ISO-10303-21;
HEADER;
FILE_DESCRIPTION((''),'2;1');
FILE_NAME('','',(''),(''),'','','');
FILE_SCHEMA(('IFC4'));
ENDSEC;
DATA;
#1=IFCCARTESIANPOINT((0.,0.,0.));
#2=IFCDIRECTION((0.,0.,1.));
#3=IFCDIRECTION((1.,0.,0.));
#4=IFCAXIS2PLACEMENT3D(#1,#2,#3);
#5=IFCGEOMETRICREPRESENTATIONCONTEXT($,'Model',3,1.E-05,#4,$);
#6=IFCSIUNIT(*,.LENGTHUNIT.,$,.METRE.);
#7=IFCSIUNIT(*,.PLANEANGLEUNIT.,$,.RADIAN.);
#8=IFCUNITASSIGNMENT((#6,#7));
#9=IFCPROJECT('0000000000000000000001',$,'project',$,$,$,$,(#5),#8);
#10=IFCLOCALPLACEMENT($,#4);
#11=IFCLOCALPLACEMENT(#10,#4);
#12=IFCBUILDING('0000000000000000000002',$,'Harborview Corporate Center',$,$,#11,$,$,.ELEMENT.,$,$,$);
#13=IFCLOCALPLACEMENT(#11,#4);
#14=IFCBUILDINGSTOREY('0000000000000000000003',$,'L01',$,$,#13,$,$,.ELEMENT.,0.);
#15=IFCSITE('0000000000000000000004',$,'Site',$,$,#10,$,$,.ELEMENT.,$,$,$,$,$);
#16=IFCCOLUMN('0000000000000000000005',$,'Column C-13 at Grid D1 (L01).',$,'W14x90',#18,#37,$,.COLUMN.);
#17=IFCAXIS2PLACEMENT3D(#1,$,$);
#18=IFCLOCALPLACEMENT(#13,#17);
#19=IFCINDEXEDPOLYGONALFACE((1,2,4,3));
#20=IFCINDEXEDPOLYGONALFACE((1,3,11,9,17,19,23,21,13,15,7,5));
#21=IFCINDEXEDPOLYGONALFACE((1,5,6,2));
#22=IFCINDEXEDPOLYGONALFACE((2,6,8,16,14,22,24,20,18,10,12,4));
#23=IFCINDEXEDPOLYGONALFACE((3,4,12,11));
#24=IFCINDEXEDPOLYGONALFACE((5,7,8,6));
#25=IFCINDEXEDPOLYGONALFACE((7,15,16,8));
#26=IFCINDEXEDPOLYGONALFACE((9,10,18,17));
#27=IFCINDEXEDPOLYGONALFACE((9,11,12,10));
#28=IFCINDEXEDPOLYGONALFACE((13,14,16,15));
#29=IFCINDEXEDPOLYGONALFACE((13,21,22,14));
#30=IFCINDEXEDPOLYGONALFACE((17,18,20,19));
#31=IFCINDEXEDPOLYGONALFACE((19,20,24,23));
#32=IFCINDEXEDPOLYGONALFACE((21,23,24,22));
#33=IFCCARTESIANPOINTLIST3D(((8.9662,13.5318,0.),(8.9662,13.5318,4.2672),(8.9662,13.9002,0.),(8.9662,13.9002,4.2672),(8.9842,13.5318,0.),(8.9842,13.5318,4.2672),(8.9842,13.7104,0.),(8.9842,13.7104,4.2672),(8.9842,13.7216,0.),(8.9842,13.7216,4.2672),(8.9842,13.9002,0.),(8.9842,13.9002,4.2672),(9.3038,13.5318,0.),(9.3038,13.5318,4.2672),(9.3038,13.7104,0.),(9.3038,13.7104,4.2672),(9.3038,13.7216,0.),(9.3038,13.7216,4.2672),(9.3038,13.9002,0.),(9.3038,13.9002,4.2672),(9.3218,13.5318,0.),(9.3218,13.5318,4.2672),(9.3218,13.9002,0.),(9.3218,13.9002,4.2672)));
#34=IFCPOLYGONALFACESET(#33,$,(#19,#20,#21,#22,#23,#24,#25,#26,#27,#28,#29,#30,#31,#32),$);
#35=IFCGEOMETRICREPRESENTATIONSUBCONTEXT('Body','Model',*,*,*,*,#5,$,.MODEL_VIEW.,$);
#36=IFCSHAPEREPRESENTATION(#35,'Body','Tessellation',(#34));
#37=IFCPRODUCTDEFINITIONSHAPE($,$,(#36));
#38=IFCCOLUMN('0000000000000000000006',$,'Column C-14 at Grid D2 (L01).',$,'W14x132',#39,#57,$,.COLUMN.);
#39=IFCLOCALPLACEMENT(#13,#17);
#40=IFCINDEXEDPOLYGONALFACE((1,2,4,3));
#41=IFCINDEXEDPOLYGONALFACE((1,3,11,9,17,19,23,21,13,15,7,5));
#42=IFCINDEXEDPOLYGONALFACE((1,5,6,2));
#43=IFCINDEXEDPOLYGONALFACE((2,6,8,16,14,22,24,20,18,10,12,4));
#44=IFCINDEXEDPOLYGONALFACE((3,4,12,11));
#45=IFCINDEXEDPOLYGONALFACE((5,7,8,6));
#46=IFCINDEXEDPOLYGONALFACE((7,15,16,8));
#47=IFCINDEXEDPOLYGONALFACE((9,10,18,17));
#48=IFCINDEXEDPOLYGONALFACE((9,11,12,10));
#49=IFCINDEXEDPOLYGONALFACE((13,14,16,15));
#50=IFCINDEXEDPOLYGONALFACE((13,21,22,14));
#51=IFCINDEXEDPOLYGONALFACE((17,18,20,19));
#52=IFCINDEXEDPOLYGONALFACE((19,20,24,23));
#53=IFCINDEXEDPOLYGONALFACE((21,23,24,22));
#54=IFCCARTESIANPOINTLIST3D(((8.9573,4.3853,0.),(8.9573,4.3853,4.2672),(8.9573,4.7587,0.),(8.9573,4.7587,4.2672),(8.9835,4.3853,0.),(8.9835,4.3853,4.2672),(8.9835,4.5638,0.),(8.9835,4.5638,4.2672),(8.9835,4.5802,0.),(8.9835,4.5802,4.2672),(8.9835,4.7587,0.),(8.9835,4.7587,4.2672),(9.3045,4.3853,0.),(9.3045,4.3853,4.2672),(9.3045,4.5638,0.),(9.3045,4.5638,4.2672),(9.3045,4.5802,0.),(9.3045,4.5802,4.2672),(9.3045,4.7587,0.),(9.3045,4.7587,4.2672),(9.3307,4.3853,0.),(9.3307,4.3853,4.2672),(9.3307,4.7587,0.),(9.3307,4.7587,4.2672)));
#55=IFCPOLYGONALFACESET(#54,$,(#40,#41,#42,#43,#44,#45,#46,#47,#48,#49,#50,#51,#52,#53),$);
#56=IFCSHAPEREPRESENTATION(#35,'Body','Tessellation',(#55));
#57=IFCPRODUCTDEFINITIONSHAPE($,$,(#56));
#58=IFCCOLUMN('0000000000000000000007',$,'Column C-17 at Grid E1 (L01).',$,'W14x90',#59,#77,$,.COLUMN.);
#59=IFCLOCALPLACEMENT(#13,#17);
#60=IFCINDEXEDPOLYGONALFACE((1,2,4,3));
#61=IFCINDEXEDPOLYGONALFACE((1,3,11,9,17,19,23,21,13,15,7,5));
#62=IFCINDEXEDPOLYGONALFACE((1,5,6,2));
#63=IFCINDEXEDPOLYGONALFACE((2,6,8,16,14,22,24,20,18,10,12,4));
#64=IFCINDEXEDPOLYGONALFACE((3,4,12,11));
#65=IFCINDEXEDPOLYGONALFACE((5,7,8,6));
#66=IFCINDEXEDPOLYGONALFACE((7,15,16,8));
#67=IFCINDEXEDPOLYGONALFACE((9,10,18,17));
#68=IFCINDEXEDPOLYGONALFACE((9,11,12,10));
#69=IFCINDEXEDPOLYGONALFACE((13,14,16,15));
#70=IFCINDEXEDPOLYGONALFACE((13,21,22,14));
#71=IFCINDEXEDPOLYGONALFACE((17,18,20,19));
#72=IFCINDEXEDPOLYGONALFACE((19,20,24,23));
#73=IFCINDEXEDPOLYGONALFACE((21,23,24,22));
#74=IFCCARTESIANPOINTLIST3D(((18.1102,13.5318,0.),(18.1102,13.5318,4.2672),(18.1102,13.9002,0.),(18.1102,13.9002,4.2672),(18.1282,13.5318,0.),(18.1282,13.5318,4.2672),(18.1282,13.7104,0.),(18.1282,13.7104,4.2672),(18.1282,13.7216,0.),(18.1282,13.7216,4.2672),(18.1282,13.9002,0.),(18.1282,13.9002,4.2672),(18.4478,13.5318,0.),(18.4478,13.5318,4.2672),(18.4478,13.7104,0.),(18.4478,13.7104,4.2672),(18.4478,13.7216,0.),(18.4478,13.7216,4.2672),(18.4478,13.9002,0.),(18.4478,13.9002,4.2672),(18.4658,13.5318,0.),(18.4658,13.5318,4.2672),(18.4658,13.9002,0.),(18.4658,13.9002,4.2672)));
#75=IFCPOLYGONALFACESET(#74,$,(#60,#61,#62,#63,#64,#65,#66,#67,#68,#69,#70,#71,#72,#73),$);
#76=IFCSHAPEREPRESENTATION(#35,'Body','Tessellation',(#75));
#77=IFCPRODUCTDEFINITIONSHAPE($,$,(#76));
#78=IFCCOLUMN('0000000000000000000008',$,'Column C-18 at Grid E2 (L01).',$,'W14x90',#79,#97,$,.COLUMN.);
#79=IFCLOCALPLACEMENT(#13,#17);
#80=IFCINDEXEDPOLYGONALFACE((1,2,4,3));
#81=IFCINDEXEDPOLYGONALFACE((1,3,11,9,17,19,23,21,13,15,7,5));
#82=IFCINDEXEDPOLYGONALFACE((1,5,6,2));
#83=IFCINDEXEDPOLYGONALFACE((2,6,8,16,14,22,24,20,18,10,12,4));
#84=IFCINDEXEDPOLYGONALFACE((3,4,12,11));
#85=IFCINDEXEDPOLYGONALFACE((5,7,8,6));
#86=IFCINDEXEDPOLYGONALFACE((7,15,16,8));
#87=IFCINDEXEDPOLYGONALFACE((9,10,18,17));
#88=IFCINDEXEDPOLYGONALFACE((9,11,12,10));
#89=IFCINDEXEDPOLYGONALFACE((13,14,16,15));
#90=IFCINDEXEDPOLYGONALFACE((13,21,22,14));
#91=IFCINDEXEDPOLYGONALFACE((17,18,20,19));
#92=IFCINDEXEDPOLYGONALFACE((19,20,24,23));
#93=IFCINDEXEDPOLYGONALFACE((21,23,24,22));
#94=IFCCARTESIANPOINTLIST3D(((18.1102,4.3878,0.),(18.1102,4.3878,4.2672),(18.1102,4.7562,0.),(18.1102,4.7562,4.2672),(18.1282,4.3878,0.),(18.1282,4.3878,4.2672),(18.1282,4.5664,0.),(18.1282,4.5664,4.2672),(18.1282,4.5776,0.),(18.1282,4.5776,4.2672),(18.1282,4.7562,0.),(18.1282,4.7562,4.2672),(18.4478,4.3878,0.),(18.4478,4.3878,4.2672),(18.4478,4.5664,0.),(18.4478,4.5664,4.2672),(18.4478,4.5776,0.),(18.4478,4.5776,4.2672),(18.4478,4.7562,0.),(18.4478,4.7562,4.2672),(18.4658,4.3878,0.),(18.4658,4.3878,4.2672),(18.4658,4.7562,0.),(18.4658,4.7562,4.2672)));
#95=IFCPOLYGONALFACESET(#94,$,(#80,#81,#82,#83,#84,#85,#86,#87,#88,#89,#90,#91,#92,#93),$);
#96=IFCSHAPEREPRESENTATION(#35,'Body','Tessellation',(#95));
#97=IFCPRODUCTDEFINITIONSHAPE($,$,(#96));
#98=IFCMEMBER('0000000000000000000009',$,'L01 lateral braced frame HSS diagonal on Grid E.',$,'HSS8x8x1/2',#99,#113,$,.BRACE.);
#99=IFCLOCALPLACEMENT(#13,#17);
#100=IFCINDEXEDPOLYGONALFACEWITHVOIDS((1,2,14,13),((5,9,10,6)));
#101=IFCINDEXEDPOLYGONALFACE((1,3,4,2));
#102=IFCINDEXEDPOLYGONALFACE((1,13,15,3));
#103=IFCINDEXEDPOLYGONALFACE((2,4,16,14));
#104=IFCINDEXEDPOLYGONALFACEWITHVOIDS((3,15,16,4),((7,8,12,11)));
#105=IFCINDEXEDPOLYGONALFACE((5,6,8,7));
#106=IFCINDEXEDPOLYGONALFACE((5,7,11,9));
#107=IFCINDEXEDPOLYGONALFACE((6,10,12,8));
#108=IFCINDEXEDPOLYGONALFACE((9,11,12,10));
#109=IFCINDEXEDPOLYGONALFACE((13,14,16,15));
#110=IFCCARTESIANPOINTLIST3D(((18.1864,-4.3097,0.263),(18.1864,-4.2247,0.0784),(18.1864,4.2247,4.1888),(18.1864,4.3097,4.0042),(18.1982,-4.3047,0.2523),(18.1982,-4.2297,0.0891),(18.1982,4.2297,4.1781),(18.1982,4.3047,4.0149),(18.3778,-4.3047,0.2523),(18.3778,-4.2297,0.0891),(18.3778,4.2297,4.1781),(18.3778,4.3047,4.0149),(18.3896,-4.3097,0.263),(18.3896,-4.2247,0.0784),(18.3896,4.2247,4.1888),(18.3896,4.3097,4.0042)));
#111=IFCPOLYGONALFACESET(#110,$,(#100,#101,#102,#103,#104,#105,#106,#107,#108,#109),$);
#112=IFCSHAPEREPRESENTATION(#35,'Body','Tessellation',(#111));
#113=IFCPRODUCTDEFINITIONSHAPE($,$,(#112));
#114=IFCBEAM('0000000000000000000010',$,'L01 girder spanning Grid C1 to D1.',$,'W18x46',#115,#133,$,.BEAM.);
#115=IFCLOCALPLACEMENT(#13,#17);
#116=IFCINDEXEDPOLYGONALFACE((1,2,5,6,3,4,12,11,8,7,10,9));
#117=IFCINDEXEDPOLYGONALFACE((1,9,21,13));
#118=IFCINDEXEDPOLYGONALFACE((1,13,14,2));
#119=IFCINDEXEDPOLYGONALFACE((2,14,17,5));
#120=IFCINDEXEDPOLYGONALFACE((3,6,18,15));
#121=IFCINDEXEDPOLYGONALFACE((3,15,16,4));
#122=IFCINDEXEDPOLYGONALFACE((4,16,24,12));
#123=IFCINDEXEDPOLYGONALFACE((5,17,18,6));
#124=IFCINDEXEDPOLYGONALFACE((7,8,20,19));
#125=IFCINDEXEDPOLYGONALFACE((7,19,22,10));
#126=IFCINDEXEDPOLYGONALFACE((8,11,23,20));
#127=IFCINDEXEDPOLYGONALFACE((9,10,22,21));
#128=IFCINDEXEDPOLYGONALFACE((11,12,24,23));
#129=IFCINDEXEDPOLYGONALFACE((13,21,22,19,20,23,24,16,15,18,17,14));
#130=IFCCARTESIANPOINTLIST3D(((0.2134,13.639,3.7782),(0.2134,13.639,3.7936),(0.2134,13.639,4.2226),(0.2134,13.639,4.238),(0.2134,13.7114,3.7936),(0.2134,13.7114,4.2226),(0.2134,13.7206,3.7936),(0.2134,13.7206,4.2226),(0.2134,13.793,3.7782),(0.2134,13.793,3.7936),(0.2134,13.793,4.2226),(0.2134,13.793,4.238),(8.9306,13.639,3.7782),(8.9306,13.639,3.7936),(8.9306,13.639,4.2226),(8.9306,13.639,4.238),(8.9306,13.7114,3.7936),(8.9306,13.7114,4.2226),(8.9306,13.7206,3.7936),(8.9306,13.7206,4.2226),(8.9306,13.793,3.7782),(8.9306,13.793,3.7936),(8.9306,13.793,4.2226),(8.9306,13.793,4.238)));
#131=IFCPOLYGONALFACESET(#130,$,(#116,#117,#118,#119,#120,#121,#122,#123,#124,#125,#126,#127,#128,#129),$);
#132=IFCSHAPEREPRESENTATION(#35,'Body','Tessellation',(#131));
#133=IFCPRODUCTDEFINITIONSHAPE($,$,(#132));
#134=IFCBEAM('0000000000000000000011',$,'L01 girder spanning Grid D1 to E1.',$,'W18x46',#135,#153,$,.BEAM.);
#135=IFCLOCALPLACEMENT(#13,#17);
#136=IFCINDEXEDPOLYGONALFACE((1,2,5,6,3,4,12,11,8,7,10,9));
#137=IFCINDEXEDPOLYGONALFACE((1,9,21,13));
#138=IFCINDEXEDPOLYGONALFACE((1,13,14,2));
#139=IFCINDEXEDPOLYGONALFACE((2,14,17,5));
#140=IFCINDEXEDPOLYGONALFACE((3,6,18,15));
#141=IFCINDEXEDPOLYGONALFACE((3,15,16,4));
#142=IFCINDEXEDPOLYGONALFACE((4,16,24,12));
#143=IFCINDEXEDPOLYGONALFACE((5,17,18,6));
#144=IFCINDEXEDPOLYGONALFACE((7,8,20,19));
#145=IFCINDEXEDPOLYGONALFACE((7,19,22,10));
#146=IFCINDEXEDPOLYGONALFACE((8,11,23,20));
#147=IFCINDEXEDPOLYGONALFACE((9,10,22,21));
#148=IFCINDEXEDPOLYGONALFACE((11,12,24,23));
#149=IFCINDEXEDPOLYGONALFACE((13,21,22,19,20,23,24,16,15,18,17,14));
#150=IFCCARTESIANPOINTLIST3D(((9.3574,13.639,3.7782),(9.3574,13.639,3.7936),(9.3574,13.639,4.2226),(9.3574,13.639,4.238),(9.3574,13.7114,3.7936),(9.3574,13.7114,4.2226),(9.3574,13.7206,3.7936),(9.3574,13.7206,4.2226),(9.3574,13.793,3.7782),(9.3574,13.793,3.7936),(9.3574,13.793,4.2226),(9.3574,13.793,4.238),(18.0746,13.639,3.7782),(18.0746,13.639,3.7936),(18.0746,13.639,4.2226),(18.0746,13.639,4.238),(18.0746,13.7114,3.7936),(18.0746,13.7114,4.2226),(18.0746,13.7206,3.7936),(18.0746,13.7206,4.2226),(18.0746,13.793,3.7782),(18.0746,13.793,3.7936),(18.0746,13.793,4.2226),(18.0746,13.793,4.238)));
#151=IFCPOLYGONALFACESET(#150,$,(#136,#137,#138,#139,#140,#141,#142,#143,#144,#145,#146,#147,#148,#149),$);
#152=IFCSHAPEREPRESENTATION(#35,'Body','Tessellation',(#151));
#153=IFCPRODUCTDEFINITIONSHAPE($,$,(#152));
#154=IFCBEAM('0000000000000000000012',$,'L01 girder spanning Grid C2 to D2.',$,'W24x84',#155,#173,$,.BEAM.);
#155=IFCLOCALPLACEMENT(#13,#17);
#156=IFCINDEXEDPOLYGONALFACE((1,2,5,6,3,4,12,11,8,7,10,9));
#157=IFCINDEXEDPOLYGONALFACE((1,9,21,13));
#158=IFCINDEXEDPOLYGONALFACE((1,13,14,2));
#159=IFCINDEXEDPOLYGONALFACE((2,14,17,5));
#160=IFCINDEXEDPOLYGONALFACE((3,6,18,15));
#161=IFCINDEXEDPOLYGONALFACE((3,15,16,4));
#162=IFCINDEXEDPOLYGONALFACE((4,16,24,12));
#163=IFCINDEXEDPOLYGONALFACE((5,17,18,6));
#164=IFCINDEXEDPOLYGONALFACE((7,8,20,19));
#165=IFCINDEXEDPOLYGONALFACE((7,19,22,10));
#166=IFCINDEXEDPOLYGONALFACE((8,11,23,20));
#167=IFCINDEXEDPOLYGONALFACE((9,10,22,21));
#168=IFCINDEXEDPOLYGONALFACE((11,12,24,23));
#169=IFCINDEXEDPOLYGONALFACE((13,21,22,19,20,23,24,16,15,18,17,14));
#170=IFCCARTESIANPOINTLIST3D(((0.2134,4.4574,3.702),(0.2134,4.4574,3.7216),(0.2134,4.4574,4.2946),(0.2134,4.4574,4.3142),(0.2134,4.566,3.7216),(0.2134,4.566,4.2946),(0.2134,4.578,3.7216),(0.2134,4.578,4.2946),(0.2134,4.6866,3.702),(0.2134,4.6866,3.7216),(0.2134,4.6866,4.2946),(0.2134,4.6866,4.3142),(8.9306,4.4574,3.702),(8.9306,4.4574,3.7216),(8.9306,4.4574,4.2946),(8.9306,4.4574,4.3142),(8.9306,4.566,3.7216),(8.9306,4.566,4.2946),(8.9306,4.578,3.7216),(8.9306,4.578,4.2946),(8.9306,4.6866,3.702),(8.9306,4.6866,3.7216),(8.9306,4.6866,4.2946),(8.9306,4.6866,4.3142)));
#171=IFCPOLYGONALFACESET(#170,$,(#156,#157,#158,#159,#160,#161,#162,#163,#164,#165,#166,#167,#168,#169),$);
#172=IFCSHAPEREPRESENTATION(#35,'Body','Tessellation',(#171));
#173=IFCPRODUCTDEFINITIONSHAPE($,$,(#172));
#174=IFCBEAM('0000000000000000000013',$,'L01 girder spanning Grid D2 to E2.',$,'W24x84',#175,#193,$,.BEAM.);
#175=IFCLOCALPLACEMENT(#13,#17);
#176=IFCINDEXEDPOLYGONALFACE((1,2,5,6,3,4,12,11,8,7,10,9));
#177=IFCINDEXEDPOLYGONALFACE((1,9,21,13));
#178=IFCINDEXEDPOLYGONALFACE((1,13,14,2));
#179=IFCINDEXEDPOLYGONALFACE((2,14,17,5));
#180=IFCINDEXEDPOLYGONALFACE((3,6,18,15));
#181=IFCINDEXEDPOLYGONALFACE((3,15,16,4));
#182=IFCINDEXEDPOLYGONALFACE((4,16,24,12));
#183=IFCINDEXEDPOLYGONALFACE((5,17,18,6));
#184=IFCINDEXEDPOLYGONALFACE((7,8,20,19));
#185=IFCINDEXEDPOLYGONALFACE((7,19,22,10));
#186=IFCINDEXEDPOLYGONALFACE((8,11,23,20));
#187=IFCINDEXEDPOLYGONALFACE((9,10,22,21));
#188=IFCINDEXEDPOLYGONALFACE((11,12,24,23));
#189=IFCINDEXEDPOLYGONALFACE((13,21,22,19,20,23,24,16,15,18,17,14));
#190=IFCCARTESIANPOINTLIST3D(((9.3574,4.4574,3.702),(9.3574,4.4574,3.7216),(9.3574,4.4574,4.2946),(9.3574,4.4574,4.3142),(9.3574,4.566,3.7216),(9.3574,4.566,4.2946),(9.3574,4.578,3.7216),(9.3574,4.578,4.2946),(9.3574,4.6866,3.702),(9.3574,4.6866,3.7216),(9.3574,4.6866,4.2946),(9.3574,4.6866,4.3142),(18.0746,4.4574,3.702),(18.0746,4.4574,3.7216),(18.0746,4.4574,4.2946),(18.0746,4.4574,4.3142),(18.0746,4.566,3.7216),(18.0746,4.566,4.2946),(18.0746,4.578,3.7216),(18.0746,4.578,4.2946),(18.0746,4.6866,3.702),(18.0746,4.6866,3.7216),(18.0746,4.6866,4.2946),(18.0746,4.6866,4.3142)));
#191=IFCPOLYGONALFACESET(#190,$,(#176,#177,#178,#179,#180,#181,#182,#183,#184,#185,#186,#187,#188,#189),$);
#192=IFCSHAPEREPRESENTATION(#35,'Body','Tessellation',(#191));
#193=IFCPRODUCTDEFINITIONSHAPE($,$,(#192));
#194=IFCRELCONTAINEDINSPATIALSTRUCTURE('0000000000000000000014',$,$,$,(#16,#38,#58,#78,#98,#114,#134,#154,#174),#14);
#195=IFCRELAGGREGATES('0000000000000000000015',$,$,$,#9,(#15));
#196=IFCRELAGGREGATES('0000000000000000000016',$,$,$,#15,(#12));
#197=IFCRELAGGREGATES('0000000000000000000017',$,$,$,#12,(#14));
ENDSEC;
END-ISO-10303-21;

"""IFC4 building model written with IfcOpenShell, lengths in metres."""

from ifc_helpers import new_model, si_unit, frame, origin_with_axes, place, context, subcontext, project, spatial, hollow_rectangle, i_section, extrude, element, save


model = new_model("IFC4")

# Units and contexts
model_context = context("Model", 3, precision=1e-05, world=origin_with_axes())
body_context = subcontext(model_context, "Body", "Model", "MODEL_VIEW")
ifc_project = project(units=[si_unit("LENGTHUNIT", "METRE"), si_unit("PLANEANGLEUNIT", "RADIAN")], contexts=[model_context])

# Site, building, storey
site_placement = place(None, origin_with_axes())
site = spatial("IfcSite", under=ifc_project, at=site_placement, Name="Site", CompositionType="ELEMENT")
building_placement = place(site_placement, origin_with_axes())
building = spatial("IfcBuilding", under=site, at=building_placement, Name="Harborview Corporate Center", CompositionType="ELEMENT")
storey_placement = place(building_placement, origin_with_axes())
storey = spatial("IfcBuildingStorey", under=building, at=storey_placement, Name="L01", CompositionType="ELEMENT", Elevation=0.0)

# Columns
column_1_placement = place(storey_placement, frame((9.144, 13.716, 0.0), z_axis=(0.0, 0.0, 1.0), x_axis=(0.0, 1.0, 0.0)))
element("IfcColumn", 1, at=column_1_placement, inside=storey, Name="Column C-13 at Grid D1 (L01).", ObjectType="W14x90", PredefinedType="COLUMN", context=body_context, shape_type="SweptSolid", body=[
    extrude(i_section(OverallWidth=0.3683, OverallDepth=0.3556, WebThickness=0.0112, FlangeThickness=0.018), origin_with_axes(), (0.0, 0.0, 1.0), 4.2672),
])
column_2_placement = place(storey_placement, frame((9.144, 4.572, 0.0), z_axis=(0.0, 0.0, 1.0), x_axis=(0.0, 1.0, 0.0)))
element("IfcColumn", 2, at=column_2_placement, inside=storey, Name="Column C-14 at Grid D2 (L01).", ObjectType="W14x132", PredefinedType="COLUMN", context=body_context, shape_type="SweptSolid", body=[
    extrude(i_section(OverallWidth=0.3734, OverallDepth=0.3734, WebThickness=0.0164, FlangeThickness=0.0262), origin_with_axes(), (0.0, 0.0, 1.0), 4.2672),
])
for number, where, z_axis, x_axis, name in (
    (3, (18.288, 13.716, 0.0), (0.0, 0.0, 1.0), (0.0, 1.0, 0.0), "Column C-17 at Grid E1 (L01)."),
    (4, (18.288, 4.572, 0.0), (0.0, 0.0, 1.0), (0.0, 1.0, 0.0), "Column C-18 at Grid E2 (L01)."),
):
    element("IfcColumn", number, at=place(storey_placement, frame(where, z_axis=z_axis, x_axis=x_axis)), inside=storey, Name=name, ObjectType="W14x90", PredefinedType="COLUMN", context=body_context, shape_type="SweptSolid", body=[
        extrude(i_section(OverallWidth=0.3683, OverallDepth=0.3556, WebThickness=0.0112, FlangeThickness=0.018), origin_with_axes(), (0.0, 0.0, 1.0), 4.2672),
    ])

# Member
member_placement = place(storey_placement, frame((18.288, -4.2672, 0.1707), z_axis=(0.0, 0.90849, 0.417906), x_axis=(-1.0, 0.0, 0.0)))
element("IfcMember", 5, at=member_placement, inside=storey, Name="L01 lateral braced frame HSS diagonal on Grid E.", ObjectType="HSS8x8x1/2", PredefinedType="BRACE", context=body_context, shape_type="SweptSolid", body=[
    extrude(hollow_rectangle(XDim=0.2032, YDim=0.2032, WallThickness=0.0118), origin_with_axes(), (0.0, 0.0, 1.0), 9.394),
])

# Beams
beam_1_placement = place(storey_placement, frame((0.2134, 13.716, 4.0081), z_axis=(1.0, 0.0, 0.0), x_axis=(0.0, 1.0, 0.0)))
element("IfcBeam", 6, at=beam_1_placement, inside=storey, Name="L01 girder spanning Grid C1 to D1.", ObjectType="W18x46", PredefinedType="BEAM", context=body_context, shape_type="SweptSolid", body=[
    extrude(i_section(OverallWidth=0.1539, OverallDepth=0.4597, WebThickness=0.0091, FlangeThickness=0.0154), origin_with_axes(), (0.0, 0.0, 1.0), 8.7173),
])
beam_2_placement = place(storey_placement, frame((9.3574, 13.716, 4.0081), z_axis=(1.0, 0.0, 0.0), x_axis=(0.0, 1.0, 0.0)))
element("IfcBeam", 7, at=beam_2_placement, inside=storey, Name="L01 girder spanning Grid D1 to E1.", ObjectType="W18x46", PredefinedType="BEAM", context=body_context, shape_type="SweptSolid", body=[
    extrude(i_section(OverallWidth=0.1539, OverallDepth=0.4597, WebThickness=0.0091, FlangeThickness=0.0154), origin_with_axes(), (0.0, 0.0, 1.0), 8.7173),
])
beam_3_placement = place(storey_placement, frame((0.2134, 4.572, 4.0081), z_axis=(1.0, 0.0, 0.0), x_axis=(0.0, 1.0, 0.0)))
element("IfcBeam", 8, at=beam_3_placement, inside=storey, Name="L01 girder spanning Grid C2 to D2.", ObjectType="W24x84", PredefinedType="BEAM", context=body_context, shape_type="SweptSolid", body=[
    extrude(i_section(OverallWidth=0.2291, OverallDepth=0.6121, WebThickness=0.0119, FlangeThickness=0.0196), origin_with_axes(), (0.0, 0.0, 1.0), 8.7173),
])
beam_4_placement = place(storey_placement, frame((9.3574, 4.572, 4.0081), z_axis=(1.0, 0.0, 0.0), x_axis=(0.0, 1.0, 0.0)))
element("IfcBeam", 9, at=beam_4_placement, inside=storey, Name="L01 girder spanning Grid D2 to E2.", ObjectType="W24x84", PredefinedType="BEAM", context=body_context, shape_type="SweptSolid", body=[
    extrude(i_section(OverallWidth=0.2291, OverallDepth=0.6121, WebThickness=0.0119, FlangeThickness=0.0196), origin_with_axes(), (0.0, 0.0, 1.0), 8.7173),
])

save(model, "model.ifc")
